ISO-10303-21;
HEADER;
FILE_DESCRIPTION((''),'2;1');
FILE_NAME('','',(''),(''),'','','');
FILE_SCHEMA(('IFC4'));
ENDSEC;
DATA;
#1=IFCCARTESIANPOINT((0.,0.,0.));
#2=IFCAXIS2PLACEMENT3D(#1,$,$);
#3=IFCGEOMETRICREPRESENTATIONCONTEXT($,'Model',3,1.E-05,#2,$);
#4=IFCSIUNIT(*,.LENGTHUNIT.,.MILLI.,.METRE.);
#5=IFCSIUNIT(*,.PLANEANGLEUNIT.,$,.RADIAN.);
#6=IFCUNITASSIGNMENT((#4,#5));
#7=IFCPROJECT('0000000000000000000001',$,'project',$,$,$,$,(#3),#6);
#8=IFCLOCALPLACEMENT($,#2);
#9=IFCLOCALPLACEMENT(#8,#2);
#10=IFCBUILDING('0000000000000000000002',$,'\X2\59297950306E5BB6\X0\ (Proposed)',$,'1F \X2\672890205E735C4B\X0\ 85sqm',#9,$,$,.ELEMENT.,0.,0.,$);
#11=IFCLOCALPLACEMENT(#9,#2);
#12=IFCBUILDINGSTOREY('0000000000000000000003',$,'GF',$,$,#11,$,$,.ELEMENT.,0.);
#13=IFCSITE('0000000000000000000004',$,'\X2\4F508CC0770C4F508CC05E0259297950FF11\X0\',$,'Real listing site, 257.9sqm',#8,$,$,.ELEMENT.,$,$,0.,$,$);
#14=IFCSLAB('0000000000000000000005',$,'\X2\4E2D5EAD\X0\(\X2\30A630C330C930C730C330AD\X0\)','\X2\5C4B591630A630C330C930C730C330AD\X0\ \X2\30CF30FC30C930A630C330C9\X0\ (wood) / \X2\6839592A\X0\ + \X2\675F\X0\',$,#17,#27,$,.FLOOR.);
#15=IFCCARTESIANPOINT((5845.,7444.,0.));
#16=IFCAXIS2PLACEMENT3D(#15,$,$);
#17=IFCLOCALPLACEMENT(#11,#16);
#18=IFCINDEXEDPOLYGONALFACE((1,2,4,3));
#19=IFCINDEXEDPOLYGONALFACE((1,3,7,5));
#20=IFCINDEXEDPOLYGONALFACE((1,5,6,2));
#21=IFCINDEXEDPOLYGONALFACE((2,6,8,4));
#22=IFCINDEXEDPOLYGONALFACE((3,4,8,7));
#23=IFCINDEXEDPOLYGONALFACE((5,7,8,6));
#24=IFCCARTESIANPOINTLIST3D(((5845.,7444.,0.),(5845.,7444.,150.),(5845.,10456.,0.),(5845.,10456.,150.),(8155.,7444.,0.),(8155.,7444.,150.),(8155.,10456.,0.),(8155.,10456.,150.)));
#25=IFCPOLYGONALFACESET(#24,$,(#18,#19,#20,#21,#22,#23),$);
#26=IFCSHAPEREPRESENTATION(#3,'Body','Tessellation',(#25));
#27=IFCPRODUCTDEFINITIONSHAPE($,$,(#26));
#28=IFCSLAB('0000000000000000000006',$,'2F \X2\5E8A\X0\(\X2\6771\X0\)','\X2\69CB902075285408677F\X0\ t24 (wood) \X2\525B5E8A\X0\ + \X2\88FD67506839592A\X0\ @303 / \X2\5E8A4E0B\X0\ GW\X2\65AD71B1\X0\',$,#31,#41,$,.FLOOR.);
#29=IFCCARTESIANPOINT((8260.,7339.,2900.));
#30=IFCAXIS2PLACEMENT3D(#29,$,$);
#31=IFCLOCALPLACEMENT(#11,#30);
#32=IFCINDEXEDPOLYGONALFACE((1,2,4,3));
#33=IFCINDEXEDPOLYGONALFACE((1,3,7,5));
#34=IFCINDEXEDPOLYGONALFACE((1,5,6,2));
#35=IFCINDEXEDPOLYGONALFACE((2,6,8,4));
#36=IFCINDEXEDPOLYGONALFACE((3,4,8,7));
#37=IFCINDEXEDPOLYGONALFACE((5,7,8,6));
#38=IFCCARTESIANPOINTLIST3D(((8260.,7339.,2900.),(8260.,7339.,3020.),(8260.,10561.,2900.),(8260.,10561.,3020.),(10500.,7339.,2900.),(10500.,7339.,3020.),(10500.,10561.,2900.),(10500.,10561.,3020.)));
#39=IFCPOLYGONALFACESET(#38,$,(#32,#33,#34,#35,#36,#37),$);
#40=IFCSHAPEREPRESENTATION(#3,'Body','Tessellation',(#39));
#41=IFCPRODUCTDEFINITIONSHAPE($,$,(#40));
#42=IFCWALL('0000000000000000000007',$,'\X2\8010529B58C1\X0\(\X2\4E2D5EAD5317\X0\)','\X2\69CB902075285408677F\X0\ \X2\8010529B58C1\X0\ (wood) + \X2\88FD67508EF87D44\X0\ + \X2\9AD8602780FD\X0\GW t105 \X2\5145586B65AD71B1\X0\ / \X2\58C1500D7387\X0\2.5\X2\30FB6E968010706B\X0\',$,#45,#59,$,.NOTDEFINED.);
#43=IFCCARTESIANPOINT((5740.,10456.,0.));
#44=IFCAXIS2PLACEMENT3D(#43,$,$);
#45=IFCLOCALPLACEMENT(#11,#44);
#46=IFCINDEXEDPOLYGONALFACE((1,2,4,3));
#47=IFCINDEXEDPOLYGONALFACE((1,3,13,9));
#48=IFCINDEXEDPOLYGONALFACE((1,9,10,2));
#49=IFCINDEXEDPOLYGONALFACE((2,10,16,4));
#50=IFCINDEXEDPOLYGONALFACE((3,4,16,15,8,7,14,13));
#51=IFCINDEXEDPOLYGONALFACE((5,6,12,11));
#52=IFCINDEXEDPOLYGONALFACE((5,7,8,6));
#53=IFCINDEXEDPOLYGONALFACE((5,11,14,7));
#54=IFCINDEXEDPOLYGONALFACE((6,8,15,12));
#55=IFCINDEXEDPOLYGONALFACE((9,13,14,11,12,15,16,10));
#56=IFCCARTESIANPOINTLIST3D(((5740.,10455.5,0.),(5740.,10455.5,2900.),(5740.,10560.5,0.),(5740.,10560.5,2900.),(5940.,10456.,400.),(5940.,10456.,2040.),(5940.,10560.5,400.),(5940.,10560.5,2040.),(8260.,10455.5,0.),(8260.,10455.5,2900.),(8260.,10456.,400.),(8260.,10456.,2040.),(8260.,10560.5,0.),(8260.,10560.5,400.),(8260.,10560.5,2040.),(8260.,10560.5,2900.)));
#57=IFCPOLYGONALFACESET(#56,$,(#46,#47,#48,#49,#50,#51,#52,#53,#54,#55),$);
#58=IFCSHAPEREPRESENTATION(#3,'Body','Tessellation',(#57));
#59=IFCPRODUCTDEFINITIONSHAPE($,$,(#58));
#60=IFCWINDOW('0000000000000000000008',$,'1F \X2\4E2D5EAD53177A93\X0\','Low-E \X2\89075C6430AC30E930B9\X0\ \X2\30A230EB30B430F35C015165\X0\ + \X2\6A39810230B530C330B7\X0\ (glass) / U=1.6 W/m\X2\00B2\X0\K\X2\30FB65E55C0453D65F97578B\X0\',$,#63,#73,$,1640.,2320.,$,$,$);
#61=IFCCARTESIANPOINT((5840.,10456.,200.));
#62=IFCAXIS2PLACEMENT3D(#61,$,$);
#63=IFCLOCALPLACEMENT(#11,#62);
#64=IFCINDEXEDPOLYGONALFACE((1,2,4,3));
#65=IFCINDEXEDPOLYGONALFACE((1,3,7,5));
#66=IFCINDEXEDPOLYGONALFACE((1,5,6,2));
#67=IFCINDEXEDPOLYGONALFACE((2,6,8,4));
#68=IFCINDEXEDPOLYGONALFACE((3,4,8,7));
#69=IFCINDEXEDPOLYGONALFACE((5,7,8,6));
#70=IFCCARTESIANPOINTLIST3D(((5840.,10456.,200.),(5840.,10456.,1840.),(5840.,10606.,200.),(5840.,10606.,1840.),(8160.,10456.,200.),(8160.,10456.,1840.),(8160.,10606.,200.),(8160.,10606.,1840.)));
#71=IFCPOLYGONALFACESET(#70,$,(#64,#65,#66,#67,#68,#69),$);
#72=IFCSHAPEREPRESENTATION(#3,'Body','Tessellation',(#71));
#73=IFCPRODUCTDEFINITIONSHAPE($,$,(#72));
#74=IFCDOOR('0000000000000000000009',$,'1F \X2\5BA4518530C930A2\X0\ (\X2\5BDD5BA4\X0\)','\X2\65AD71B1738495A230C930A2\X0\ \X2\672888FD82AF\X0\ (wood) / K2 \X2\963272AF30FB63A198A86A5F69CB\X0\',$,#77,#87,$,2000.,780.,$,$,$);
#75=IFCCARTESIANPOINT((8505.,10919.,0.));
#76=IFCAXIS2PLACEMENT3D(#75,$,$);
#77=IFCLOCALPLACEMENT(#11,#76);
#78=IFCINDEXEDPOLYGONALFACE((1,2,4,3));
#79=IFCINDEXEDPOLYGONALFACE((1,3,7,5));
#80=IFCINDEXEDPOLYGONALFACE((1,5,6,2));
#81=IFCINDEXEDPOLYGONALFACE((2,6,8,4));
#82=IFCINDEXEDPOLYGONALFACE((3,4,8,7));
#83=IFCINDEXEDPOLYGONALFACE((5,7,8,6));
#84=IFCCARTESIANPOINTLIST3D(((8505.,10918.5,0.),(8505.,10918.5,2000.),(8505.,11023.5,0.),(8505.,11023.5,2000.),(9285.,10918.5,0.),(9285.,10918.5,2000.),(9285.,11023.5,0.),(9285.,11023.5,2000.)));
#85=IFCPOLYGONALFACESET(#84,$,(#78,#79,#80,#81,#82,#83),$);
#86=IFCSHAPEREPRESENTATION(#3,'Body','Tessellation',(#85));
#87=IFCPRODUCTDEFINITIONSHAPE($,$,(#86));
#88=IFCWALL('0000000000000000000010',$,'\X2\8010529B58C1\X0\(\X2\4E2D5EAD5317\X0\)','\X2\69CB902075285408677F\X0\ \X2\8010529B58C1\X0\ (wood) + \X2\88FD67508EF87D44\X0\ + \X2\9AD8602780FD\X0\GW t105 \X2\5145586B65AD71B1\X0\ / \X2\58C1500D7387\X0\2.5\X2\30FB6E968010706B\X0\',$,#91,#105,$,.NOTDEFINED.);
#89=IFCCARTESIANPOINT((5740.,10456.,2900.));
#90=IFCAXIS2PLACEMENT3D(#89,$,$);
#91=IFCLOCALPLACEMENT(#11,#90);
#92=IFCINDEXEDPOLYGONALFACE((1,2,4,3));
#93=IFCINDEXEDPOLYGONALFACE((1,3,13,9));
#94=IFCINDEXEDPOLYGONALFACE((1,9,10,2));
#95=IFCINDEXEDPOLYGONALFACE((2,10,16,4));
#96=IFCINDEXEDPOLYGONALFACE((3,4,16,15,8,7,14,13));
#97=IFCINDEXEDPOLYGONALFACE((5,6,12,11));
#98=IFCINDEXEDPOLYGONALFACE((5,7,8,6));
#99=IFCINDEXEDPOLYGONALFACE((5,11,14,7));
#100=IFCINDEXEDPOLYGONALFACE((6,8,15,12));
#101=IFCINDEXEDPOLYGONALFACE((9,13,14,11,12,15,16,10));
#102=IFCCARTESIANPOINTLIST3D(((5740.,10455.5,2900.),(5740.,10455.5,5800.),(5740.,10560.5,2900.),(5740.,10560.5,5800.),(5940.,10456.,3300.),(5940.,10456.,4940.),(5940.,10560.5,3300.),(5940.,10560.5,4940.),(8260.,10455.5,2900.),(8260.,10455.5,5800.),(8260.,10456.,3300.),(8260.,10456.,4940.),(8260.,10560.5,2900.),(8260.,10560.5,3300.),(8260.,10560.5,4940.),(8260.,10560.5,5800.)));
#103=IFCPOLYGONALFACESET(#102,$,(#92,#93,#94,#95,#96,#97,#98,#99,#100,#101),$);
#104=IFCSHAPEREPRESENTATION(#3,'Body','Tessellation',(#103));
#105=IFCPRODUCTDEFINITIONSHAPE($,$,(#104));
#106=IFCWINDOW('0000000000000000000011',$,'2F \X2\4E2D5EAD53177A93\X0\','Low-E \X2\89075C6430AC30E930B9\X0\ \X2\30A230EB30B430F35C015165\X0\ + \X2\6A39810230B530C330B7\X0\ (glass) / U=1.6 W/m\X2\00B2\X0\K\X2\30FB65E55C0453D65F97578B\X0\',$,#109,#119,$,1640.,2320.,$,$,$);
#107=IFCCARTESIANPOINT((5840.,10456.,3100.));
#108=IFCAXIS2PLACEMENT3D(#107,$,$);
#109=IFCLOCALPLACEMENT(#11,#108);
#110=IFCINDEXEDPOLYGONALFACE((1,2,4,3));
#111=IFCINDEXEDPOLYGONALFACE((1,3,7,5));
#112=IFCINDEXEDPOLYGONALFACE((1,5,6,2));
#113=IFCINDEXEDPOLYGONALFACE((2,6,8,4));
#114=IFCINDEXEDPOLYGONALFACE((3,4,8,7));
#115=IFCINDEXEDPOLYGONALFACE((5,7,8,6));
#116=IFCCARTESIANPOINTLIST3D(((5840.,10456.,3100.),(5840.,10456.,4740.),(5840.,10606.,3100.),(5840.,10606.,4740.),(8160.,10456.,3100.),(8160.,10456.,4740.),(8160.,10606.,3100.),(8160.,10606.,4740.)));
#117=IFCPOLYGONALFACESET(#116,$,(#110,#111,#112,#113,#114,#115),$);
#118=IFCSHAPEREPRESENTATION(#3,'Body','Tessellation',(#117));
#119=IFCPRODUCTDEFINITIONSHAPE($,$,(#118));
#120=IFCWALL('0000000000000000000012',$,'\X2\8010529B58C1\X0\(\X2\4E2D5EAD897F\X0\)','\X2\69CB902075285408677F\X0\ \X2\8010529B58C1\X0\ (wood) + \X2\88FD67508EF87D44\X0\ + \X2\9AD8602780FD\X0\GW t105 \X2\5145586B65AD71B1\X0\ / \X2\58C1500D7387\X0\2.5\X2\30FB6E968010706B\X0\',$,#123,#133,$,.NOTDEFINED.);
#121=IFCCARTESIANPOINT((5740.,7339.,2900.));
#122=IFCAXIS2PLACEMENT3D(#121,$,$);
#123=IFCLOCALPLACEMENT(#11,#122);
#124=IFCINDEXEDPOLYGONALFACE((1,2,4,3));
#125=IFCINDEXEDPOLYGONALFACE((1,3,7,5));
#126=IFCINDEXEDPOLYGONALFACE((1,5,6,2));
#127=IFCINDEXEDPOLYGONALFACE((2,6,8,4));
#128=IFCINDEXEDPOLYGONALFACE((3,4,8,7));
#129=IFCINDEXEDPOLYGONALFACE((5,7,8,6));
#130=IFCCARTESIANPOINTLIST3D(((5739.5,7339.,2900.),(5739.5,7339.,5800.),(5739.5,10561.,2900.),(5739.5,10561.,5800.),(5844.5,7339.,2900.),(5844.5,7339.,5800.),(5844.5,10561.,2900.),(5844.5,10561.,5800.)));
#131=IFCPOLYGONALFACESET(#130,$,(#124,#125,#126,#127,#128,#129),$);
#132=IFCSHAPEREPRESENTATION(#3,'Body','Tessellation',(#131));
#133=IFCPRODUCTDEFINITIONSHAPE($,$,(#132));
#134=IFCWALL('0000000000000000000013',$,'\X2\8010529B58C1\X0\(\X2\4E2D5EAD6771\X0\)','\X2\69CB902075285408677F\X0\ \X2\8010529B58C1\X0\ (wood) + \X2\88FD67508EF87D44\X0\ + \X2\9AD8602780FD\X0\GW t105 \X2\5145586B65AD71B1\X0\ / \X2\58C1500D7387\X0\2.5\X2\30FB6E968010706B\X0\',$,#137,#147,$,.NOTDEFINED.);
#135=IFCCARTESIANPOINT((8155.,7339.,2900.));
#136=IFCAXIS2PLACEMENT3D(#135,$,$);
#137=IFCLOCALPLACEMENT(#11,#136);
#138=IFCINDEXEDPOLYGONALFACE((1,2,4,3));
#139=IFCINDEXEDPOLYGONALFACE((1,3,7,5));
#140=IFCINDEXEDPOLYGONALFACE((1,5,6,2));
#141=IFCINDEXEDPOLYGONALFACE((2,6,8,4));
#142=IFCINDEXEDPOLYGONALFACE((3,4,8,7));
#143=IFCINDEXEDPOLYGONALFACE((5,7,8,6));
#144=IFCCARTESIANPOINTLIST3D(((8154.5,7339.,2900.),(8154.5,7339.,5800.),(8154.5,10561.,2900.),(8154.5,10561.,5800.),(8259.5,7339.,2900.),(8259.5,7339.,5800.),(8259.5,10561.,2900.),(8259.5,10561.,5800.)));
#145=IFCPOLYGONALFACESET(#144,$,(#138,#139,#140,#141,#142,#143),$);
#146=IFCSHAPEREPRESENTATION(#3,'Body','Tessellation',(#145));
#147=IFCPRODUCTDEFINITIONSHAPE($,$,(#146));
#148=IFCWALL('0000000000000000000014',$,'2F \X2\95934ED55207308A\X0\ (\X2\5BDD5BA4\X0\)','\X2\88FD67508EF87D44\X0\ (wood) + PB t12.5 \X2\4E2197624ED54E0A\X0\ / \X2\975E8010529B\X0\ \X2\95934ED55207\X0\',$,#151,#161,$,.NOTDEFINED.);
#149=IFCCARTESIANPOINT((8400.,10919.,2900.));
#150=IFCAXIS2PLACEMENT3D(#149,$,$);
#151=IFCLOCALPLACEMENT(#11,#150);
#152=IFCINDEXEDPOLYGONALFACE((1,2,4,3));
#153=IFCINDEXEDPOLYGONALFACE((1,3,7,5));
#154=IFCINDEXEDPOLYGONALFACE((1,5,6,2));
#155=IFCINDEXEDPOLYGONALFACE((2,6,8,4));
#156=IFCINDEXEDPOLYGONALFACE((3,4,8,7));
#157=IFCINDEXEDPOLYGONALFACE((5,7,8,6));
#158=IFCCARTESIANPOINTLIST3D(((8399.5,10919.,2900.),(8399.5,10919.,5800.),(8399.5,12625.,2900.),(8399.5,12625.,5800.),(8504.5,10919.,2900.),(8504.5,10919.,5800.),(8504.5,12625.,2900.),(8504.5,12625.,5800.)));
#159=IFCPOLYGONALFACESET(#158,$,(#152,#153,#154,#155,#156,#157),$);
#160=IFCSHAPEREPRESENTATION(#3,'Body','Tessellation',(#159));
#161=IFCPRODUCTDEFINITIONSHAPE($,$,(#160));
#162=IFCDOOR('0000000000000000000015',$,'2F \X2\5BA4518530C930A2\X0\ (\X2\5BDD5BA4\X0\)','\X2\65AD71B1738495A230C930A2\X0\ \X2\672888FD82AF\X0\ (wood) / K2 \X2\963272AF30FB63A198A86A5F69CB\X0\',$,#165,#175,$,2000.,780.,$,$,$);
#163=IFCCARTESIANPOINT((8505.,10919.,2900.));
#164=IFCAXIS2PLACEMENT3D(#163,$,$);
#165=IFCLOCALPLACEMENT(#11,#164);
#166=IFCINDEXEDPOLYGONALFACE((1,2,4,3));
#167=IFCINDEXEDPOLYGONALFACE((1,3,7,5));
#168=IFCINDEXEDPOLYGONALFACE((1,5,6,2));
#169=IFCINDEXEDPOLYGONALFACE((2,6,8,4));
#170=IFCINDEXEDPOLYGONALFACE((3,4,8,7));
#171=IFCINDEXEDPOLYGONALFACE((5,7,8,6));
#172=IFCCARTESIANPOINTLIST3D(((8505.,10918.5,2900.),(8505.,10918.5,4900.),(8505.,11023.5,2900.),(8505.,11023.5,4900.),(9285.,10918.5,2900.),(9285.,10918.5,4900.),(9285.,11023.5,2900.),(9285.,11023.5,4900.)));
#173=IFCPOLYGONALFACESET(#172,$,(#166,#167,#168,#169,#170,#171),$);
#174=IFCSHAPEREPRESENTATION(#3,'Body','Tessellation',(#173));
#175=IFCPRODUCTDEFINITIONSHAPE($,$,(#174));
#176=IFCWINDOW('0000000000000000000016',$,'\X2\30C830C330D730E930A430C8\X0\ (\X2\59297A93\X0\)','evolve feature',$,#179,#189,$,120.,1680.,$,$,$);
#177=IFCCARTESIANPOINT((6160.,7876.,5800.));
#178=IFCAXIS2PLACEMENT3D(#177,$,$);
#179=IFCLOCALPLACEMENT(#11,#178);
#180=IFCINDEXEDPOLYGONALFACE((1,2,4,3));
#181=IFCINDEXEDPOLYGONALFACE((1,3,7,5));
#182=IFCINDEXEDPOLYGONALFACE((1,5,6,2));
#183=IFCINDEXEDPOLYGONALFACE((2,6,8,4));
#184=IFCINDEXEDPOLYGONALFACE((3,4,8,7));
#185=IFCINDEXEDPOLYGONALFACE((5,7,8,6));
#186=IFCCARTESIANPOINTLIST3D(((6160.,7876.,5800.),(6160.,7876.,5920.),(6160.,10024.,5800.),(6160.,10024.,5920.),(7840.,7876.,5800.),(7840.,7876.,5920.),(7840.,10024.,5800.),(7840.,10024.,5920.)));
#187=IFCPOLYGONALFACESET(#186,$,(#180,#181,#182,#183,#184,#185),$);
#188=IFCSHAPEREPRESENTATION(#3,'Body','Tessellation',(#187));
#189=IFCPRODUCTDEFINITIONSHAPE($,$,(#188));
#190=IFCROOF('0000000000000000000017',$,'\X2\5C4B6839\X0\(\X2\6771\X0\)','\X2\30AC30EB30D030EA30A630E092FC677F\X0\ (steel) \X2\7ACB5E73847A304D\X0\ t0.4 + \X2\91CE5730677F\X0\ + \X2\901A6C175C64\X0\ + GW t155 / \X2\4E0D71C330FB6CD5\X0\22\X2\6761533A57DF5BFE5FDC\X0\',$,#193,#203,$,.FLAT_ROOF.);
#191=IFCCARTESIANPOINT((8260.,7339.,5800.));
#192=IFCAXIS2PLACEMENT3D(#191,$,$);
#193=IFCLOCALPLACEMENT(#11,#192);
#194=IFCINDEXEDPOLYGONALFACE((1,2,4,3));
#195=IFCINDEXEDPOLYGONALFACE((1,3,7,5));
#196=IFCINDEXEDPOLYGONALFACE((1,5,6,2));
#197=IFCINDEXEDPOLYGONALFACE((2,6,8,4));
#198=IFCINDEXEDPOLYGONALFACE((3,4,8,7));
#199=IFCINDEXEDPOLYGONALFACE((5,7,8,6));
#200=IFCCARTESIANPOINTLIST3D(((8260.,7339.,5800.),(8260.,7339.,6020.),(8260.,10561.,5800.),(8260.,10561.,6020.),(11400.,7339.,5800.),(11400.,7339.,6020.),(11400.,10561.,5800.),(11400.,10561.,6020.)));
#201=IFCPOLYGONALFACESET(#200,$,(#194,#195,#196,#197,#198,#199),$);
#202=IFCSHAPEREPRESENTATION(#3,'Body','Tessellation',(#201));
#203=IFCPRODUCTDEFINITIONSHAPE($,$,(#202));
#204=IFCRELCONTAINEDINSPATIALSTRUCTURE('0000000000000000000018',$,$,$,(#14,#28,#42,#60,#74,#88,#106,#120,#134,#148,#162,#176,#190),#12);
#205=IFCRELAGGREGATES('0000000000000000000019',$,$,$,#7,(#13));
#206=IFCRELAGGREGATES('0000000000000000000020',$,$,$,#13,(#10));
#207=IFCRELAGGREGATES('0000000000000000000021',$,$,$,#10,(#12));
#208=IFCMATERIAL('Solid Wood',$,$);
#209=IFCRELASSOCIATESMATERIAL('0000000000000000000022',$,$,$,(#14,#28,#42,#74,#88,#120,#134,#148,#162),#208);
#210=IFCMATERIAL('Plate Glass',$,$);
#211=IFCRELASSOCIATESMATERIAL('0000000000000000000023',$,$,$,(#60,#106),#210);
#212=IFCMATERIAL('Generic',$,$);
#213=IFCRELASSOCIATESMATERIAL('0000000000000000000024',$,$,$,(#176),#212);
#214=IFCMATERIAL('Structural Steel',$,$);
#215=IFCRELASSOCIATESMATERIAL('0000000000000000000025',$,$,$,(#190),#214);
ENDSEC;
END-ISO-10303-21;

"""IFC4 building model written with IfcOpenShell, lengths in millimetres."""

from ifc_helpers import new_model, si_unit, frame, frame_2d, origin, place, context, project, spatial, rectangle, extrude, material, element, fill, save


model = new_model("IFC4")

# Units and contexts
model_context = context("Model", 3, precision=1e-05, world=origin())
ifc_project = project(units=[si_unit("LENGTHUNIT", "METRE", prefix="MILLI"), si_unit("PLANEANGLEUNIT", "RADIAN")], contexts=[model_context])

# Site, building, storey
site_placement = place(None, origin())
site = spatial("IfcSite", under=ifc_project, at=site_placement, Name="佐賀県佐賀市天祐１", ObjectType="Real listing site, 257.9sqm", CompositionType="ELEMENT", RefElevation=0.0)
building_placement = place(site_placement, origin())
building = spatial("IfcBuilding", under=site, at=building_placement, Name="天祐の家 (Proposed)", ObjectType="1F 木造平屋 85sqm", CompositionType="ELEMENT", ElevationOfRefHeight=0.0, ElevationOfTerrain=0.0)
storey_placement = place(building_placement, origin())
storey = spatial("IfcBuildingStorey", under=building, at=storey_placement, Name="GF", CompositionType="ELEMENT", Elevation=0.0)

# Slabs
ifc_material_1 = material(Name="Solid Wood")
slab_1_placement = place(storey_placement, frame((5845.0, 7444.0, 0.0)))
element("IfcSlab", 1, at=slab_1_placement, inside=storey, material=ifc_material_1, Name="中庭(ウッドデッキ)", Description="屋外ウッドデッキ ハードウッド (wood) / 根太 + 束", PredefinedType="FLOOR", context=model_context, shape_type="SweptSolid", body=[
    extrude(rectangle(XDim=2310.0, YDim=3012.0, at=frame_2d((1155.0, 1506.0))), frame((5845.0, 7444.0, 0.0)), (0.0, 0.0, 1.0), 150.0),
])
slab_2_placement = place(storey_placement, frame((8260.0, 7339.0, 2900.0)))
element("IfcSlab", 2, at=slab_2_placement, inside=storey, material=ifc_material_1, Name="2F 床(東)", Description="構造用合板 t24 (wood) 剛床 + 製材根太 @303 / 床下 GW断熱", PredefinedType="FLOOR", context=model_context, shape_type="SweptSolid", body=[
    extrude(rectangle(XDim=2240.0, YDim=3222.0, at=frame_2d((1120.0, 1611.0))), frame((8260.0, 7339.0, 2900.0)), (0.0, 0.0, 1.0), 120.0),
])

# Wall, opening, window
wall_1_placement = place(storey_placement, frame((5740.0, 10456.0, 0.0)))
wall_1 = element("IfcWall", 3, at=wall_1_placement, inside=storey, material=ifc_material_1, Name="耐力壁(中庭北)", Description="構造用合板 耐力壁 (wood) + 製材軸組 + 高性能GW t105 充填断熱 / 壁倍率2.5・準耐火", PredefinedType="NOTDEFINED", context=model_context, shape_type="SweptSolid", body=[
    extrude(rectangle(XDim=2520.0, YDim=105.0, at=frame_2d((1260.0, 52.0))), frame((5740.0, 10456.0, 0.0)), (0.0, 0.0, 1.0), 2900.0),
])
opening_1_placement = place(storey_placement, frame((5840.0, 10456.0, 200.0)))
opening_1 = element("IfcOpeningElement", 4, at=opening_1_placement, cuts=wall_1, PredefinedType="NOTDEFINED", context=model_context, shape_type="SweptSolid", body=[
    extrude(rectangle(XDim=2320.0, YDim=150.0, at=frame_2d((1160.0, 75.0))), frame((5840.0, 10456.0, 200.0)), (0.0, 0.0, 1.0), 1640.0),
])
ifc_material_2 = material(Name="Plate Glass")
window_1_placement = place(storey_placement, frame((5840.0, 10456.0, 200.0)))
window_1 = element("IfcWindow", 5, at=window_1_placement, inside=storey, material=ifc_material_2, Name="1F 中庭北窓", Description="Low-E 複層ガラス アルゴン封入 + 樹脂サッシ (glass) / U=1.6 W/m²K・日射取得型", OverallHeight=1640.0, OverallWidth=2320.0, context=model_context, shape_type="SweptSolid", body=[
    extrude(rectangle(XDim=2320.0, YDim=150.0, at=frame_2d((1160.0, 75.0))), frame((5840.0, 10456.0, 200.0)), (0.0, 0.0, 1.0), 1640.0),
])
fill(opening_1, window_1)

# Door
door_1_placement = place(storey_placement, frame((8505.0, 10919.0, 0.0)))
element("IfcDoor", 6, at=door_1_placement, inside=storey, material=ifc_material_1, Name="1F 室内ドア (寝室)", Description="断熱玄関ドア 木製芯 (wood) / K2 防犯・採風機構", OverallHeight=2000.0, OverallWidth=780.0, context=model_context, shape_type="SweptSolid", body=[
    extrude(rectangle(XDim=780.0, YDim=105.0, at=frame_2d((390.0, 52.0))), frame((8505.0, 10919.0, 0.0)), (0.0, 0.0, 1.0), 2000.0),
])

# Wall, opening, window
wall_2_placement = place(storey_placement, frame((5740.0, 10456.0, 2900.0)))
wall_2 = element("IfcWall", 7, at=wall_2_placement, inside=storey, material=ifc_material_1, Name="耐力壁(中庭北)", Description="構造用合板 耐力壁 (wood) + 製材軸組 + 高性能GW t105 充填断熱 / 壁倍率2.5・準耐火", PredefinedType="NOTDEFINED", context=model_context, shape_type="SweptSolid", body=[
    extrude(rectangle(XDim=2520.0, YDim=105.0, at=frame_2d((1260.0, 52.0))), frame((5740.0, 10456.0, 2900.0)), (0.0, 0.0, 1.0), 2900.0),
])
opening_2_placement = place(storey_placement, frame((5840.0, 10456.0, 3100.0)))
opening_2 = element("IfcOpeningElement", 8, at=opening_2_placement, cuts=wall_2, PredefinedType="NOTDEFINED", context=model_context, shape_type="SweptSolid", body=[
    extrude(rectangle(XDim=2320.0, YDim=150.0, at=frame_2d((1160.0, 75.0))), frame((5840.0, 10456.0, 3100.0)), (0.0, 0.0, 1.0), 1640.0),
])
window_2_placement = place(storey_placement, frame((5840.0, 10456.0, 3100.0)))
window_2 = element("IfcWindow", 9, at=window_2_placement, inside=storey, material=ifc_material_2, Name="2F 中庭北窓", Description="Low-E 複層ガラス アルゴン封入 + 樹脂サッシ (glass) / U=1.6 W/m²K・日射取得型", OverallHeight=1640.0, OverallWidth=2320.0, context=model_context, shape_type="SweptSolid", body=[
    extrude(rectangle(XDim=2320.0, YDim=150.0, at=frame_2d((1160.0, 75.0))), frame((5840.0, 10456.0, 3100.0)), (0.0, 0.0, 1.0), 1640.0),
])
fill(opening_2, window_2)

# Walls
wall_3_placement = place(storey_placement, frame((5740.0, 7339.0, 2900.0)))
element("IfcWall", 10, at=wall_3_placement, inside=storey, material=ifc_material_1, Name="耐力壁(中庭西)", Description="構造用合板 耐力壁 (wood) + 製材軸組 + 高性能GW t105 充填断熱 / 壁倍率2.5・準耐火", PredefinedType="NOTDEFINED", context=model_context, shape_type="SweptSolid", body=[
    extrude(rectangle(XDim=105.0, YDim=3222.0, at=frame_2d((52.0, 1611.0))), frame((5740.0, 7339.0, 2900.0)), (0.0, 0.0, 1.0), 2900.0),
])
wall_4_placement = place(storey_placement, frame((8155.0, 7339.0, 2900.0)))
element("IfcWall", 11, at=wall_4_placement, inside=storey, material=ifc_material_1, Name="耐力壁(中庭東)", Description="構造用合板 耐力壁 (wood) + 製材軸組 + 高性能GW t105 充填断熱 / 壁倍率2.5・準耐火", PredefinedType="NOTDEFINED", context=model_context, shape_type="SweptSolid", body=[
    extrude(rectangle(XDim=105.0, YDim=3222.0, at=frame_2d((52.0, 1611.0))), frame((8155.0, 7339.0, 2900.0)), (0.0, 0.0, 1.0), 2900.0),
])
wall_5_placement = place(storey_placement, frame((8400.0, 10919.0, 2900.0)))
element("IfcWall", 12, at=wall_5_placement, inside=storey, material=ifc_material_1, Name="2F 間仕切り (寝室)", Description="製材軸組 (wood) + PB t12.5 両面仕上 / 非耐力 間仕切", PredefinedType="NOTDEFINED", context=model_context, shape_type="SweptSolid", body=[
    extrude(rectangle(XDim=105.0, YDim=1706.0, at=frame_2d((52.0, 853.0))), frame((8400.0, 10919.0, 2900.0)), (0.0, 0.0, 1.0), 2900.0),
])

# Door
door_2_placement = place(storey_placement, frame((8505.0, 10919.0, 2900.0)))
element("IfcDoor", 13, at=door_2_placement, inside=storey, material=ifc_material_1, Name="2F 室内ドア (寝室)", Description="断熱玄関ドア 木製芯 (wood) / K2 防犯・採風機構", OverallHeight=2000.0, OverallWidth=780.0, context=model_context, shape_type="SweptSolid", body=[
    extrude(rectangle(XDim=780.0, YDim=105.0, at=frame_2d((390.0, 52.0))), frame((8505.0, 10919.0, 2900.0)), (0.0, 0.0, 1.0), 2000.0),
])

# Window
ifc_material_3 = material(Name="Generic")
window_3_placement = place(storey_placement, frame((6160.0, 7876.0, 5800.0)))
element("IfcWindow", 14, at=window_3_placement, inside=storey, material=ifc_material_3, Name="トップライト (天窓)", Description="evolve feature", OverallHeight=120.0, OverallWidth=1680.0, context=model_context, shape_type="SweptSolid", body=[
    extrude(rectangle(XDim=1680.0, YDim=2148.0, at=frame_2d((840.0, 1074.0))), frame((6160.0, 7876.0, 5800.0)), (0.0, 0.0, 1.0), 120.0),
])

# Roof
ifc_material_4 = material(Name="Structural Steel")
roof_placement = place(storey_placement, frame((8260.0, 7339.0, 5800.0)))
element("IfcRoof", 15, at=roof_placement, inside=storey, material=ifc_material_4, Name="屋根(東)", Description="ガルバリウム鋼板 (steel) 立平葺き t0.4 + 野地板 + 通気層 + GW t155 / 不燃・法22条区域対応", PredefinedType="FLAT_ROOF", context=model_context, shape_type="SweptSolid", body=[
    extrude(rectangle(XDim=3140.0, YDim=3222.0, at=frame_2d((1570.0, 1611.0))), frame((8260.0, 7339.0, 5800.0)), (0.0, 0.0, 1.0), 220.0),
])

save(model, "model.ifc")
